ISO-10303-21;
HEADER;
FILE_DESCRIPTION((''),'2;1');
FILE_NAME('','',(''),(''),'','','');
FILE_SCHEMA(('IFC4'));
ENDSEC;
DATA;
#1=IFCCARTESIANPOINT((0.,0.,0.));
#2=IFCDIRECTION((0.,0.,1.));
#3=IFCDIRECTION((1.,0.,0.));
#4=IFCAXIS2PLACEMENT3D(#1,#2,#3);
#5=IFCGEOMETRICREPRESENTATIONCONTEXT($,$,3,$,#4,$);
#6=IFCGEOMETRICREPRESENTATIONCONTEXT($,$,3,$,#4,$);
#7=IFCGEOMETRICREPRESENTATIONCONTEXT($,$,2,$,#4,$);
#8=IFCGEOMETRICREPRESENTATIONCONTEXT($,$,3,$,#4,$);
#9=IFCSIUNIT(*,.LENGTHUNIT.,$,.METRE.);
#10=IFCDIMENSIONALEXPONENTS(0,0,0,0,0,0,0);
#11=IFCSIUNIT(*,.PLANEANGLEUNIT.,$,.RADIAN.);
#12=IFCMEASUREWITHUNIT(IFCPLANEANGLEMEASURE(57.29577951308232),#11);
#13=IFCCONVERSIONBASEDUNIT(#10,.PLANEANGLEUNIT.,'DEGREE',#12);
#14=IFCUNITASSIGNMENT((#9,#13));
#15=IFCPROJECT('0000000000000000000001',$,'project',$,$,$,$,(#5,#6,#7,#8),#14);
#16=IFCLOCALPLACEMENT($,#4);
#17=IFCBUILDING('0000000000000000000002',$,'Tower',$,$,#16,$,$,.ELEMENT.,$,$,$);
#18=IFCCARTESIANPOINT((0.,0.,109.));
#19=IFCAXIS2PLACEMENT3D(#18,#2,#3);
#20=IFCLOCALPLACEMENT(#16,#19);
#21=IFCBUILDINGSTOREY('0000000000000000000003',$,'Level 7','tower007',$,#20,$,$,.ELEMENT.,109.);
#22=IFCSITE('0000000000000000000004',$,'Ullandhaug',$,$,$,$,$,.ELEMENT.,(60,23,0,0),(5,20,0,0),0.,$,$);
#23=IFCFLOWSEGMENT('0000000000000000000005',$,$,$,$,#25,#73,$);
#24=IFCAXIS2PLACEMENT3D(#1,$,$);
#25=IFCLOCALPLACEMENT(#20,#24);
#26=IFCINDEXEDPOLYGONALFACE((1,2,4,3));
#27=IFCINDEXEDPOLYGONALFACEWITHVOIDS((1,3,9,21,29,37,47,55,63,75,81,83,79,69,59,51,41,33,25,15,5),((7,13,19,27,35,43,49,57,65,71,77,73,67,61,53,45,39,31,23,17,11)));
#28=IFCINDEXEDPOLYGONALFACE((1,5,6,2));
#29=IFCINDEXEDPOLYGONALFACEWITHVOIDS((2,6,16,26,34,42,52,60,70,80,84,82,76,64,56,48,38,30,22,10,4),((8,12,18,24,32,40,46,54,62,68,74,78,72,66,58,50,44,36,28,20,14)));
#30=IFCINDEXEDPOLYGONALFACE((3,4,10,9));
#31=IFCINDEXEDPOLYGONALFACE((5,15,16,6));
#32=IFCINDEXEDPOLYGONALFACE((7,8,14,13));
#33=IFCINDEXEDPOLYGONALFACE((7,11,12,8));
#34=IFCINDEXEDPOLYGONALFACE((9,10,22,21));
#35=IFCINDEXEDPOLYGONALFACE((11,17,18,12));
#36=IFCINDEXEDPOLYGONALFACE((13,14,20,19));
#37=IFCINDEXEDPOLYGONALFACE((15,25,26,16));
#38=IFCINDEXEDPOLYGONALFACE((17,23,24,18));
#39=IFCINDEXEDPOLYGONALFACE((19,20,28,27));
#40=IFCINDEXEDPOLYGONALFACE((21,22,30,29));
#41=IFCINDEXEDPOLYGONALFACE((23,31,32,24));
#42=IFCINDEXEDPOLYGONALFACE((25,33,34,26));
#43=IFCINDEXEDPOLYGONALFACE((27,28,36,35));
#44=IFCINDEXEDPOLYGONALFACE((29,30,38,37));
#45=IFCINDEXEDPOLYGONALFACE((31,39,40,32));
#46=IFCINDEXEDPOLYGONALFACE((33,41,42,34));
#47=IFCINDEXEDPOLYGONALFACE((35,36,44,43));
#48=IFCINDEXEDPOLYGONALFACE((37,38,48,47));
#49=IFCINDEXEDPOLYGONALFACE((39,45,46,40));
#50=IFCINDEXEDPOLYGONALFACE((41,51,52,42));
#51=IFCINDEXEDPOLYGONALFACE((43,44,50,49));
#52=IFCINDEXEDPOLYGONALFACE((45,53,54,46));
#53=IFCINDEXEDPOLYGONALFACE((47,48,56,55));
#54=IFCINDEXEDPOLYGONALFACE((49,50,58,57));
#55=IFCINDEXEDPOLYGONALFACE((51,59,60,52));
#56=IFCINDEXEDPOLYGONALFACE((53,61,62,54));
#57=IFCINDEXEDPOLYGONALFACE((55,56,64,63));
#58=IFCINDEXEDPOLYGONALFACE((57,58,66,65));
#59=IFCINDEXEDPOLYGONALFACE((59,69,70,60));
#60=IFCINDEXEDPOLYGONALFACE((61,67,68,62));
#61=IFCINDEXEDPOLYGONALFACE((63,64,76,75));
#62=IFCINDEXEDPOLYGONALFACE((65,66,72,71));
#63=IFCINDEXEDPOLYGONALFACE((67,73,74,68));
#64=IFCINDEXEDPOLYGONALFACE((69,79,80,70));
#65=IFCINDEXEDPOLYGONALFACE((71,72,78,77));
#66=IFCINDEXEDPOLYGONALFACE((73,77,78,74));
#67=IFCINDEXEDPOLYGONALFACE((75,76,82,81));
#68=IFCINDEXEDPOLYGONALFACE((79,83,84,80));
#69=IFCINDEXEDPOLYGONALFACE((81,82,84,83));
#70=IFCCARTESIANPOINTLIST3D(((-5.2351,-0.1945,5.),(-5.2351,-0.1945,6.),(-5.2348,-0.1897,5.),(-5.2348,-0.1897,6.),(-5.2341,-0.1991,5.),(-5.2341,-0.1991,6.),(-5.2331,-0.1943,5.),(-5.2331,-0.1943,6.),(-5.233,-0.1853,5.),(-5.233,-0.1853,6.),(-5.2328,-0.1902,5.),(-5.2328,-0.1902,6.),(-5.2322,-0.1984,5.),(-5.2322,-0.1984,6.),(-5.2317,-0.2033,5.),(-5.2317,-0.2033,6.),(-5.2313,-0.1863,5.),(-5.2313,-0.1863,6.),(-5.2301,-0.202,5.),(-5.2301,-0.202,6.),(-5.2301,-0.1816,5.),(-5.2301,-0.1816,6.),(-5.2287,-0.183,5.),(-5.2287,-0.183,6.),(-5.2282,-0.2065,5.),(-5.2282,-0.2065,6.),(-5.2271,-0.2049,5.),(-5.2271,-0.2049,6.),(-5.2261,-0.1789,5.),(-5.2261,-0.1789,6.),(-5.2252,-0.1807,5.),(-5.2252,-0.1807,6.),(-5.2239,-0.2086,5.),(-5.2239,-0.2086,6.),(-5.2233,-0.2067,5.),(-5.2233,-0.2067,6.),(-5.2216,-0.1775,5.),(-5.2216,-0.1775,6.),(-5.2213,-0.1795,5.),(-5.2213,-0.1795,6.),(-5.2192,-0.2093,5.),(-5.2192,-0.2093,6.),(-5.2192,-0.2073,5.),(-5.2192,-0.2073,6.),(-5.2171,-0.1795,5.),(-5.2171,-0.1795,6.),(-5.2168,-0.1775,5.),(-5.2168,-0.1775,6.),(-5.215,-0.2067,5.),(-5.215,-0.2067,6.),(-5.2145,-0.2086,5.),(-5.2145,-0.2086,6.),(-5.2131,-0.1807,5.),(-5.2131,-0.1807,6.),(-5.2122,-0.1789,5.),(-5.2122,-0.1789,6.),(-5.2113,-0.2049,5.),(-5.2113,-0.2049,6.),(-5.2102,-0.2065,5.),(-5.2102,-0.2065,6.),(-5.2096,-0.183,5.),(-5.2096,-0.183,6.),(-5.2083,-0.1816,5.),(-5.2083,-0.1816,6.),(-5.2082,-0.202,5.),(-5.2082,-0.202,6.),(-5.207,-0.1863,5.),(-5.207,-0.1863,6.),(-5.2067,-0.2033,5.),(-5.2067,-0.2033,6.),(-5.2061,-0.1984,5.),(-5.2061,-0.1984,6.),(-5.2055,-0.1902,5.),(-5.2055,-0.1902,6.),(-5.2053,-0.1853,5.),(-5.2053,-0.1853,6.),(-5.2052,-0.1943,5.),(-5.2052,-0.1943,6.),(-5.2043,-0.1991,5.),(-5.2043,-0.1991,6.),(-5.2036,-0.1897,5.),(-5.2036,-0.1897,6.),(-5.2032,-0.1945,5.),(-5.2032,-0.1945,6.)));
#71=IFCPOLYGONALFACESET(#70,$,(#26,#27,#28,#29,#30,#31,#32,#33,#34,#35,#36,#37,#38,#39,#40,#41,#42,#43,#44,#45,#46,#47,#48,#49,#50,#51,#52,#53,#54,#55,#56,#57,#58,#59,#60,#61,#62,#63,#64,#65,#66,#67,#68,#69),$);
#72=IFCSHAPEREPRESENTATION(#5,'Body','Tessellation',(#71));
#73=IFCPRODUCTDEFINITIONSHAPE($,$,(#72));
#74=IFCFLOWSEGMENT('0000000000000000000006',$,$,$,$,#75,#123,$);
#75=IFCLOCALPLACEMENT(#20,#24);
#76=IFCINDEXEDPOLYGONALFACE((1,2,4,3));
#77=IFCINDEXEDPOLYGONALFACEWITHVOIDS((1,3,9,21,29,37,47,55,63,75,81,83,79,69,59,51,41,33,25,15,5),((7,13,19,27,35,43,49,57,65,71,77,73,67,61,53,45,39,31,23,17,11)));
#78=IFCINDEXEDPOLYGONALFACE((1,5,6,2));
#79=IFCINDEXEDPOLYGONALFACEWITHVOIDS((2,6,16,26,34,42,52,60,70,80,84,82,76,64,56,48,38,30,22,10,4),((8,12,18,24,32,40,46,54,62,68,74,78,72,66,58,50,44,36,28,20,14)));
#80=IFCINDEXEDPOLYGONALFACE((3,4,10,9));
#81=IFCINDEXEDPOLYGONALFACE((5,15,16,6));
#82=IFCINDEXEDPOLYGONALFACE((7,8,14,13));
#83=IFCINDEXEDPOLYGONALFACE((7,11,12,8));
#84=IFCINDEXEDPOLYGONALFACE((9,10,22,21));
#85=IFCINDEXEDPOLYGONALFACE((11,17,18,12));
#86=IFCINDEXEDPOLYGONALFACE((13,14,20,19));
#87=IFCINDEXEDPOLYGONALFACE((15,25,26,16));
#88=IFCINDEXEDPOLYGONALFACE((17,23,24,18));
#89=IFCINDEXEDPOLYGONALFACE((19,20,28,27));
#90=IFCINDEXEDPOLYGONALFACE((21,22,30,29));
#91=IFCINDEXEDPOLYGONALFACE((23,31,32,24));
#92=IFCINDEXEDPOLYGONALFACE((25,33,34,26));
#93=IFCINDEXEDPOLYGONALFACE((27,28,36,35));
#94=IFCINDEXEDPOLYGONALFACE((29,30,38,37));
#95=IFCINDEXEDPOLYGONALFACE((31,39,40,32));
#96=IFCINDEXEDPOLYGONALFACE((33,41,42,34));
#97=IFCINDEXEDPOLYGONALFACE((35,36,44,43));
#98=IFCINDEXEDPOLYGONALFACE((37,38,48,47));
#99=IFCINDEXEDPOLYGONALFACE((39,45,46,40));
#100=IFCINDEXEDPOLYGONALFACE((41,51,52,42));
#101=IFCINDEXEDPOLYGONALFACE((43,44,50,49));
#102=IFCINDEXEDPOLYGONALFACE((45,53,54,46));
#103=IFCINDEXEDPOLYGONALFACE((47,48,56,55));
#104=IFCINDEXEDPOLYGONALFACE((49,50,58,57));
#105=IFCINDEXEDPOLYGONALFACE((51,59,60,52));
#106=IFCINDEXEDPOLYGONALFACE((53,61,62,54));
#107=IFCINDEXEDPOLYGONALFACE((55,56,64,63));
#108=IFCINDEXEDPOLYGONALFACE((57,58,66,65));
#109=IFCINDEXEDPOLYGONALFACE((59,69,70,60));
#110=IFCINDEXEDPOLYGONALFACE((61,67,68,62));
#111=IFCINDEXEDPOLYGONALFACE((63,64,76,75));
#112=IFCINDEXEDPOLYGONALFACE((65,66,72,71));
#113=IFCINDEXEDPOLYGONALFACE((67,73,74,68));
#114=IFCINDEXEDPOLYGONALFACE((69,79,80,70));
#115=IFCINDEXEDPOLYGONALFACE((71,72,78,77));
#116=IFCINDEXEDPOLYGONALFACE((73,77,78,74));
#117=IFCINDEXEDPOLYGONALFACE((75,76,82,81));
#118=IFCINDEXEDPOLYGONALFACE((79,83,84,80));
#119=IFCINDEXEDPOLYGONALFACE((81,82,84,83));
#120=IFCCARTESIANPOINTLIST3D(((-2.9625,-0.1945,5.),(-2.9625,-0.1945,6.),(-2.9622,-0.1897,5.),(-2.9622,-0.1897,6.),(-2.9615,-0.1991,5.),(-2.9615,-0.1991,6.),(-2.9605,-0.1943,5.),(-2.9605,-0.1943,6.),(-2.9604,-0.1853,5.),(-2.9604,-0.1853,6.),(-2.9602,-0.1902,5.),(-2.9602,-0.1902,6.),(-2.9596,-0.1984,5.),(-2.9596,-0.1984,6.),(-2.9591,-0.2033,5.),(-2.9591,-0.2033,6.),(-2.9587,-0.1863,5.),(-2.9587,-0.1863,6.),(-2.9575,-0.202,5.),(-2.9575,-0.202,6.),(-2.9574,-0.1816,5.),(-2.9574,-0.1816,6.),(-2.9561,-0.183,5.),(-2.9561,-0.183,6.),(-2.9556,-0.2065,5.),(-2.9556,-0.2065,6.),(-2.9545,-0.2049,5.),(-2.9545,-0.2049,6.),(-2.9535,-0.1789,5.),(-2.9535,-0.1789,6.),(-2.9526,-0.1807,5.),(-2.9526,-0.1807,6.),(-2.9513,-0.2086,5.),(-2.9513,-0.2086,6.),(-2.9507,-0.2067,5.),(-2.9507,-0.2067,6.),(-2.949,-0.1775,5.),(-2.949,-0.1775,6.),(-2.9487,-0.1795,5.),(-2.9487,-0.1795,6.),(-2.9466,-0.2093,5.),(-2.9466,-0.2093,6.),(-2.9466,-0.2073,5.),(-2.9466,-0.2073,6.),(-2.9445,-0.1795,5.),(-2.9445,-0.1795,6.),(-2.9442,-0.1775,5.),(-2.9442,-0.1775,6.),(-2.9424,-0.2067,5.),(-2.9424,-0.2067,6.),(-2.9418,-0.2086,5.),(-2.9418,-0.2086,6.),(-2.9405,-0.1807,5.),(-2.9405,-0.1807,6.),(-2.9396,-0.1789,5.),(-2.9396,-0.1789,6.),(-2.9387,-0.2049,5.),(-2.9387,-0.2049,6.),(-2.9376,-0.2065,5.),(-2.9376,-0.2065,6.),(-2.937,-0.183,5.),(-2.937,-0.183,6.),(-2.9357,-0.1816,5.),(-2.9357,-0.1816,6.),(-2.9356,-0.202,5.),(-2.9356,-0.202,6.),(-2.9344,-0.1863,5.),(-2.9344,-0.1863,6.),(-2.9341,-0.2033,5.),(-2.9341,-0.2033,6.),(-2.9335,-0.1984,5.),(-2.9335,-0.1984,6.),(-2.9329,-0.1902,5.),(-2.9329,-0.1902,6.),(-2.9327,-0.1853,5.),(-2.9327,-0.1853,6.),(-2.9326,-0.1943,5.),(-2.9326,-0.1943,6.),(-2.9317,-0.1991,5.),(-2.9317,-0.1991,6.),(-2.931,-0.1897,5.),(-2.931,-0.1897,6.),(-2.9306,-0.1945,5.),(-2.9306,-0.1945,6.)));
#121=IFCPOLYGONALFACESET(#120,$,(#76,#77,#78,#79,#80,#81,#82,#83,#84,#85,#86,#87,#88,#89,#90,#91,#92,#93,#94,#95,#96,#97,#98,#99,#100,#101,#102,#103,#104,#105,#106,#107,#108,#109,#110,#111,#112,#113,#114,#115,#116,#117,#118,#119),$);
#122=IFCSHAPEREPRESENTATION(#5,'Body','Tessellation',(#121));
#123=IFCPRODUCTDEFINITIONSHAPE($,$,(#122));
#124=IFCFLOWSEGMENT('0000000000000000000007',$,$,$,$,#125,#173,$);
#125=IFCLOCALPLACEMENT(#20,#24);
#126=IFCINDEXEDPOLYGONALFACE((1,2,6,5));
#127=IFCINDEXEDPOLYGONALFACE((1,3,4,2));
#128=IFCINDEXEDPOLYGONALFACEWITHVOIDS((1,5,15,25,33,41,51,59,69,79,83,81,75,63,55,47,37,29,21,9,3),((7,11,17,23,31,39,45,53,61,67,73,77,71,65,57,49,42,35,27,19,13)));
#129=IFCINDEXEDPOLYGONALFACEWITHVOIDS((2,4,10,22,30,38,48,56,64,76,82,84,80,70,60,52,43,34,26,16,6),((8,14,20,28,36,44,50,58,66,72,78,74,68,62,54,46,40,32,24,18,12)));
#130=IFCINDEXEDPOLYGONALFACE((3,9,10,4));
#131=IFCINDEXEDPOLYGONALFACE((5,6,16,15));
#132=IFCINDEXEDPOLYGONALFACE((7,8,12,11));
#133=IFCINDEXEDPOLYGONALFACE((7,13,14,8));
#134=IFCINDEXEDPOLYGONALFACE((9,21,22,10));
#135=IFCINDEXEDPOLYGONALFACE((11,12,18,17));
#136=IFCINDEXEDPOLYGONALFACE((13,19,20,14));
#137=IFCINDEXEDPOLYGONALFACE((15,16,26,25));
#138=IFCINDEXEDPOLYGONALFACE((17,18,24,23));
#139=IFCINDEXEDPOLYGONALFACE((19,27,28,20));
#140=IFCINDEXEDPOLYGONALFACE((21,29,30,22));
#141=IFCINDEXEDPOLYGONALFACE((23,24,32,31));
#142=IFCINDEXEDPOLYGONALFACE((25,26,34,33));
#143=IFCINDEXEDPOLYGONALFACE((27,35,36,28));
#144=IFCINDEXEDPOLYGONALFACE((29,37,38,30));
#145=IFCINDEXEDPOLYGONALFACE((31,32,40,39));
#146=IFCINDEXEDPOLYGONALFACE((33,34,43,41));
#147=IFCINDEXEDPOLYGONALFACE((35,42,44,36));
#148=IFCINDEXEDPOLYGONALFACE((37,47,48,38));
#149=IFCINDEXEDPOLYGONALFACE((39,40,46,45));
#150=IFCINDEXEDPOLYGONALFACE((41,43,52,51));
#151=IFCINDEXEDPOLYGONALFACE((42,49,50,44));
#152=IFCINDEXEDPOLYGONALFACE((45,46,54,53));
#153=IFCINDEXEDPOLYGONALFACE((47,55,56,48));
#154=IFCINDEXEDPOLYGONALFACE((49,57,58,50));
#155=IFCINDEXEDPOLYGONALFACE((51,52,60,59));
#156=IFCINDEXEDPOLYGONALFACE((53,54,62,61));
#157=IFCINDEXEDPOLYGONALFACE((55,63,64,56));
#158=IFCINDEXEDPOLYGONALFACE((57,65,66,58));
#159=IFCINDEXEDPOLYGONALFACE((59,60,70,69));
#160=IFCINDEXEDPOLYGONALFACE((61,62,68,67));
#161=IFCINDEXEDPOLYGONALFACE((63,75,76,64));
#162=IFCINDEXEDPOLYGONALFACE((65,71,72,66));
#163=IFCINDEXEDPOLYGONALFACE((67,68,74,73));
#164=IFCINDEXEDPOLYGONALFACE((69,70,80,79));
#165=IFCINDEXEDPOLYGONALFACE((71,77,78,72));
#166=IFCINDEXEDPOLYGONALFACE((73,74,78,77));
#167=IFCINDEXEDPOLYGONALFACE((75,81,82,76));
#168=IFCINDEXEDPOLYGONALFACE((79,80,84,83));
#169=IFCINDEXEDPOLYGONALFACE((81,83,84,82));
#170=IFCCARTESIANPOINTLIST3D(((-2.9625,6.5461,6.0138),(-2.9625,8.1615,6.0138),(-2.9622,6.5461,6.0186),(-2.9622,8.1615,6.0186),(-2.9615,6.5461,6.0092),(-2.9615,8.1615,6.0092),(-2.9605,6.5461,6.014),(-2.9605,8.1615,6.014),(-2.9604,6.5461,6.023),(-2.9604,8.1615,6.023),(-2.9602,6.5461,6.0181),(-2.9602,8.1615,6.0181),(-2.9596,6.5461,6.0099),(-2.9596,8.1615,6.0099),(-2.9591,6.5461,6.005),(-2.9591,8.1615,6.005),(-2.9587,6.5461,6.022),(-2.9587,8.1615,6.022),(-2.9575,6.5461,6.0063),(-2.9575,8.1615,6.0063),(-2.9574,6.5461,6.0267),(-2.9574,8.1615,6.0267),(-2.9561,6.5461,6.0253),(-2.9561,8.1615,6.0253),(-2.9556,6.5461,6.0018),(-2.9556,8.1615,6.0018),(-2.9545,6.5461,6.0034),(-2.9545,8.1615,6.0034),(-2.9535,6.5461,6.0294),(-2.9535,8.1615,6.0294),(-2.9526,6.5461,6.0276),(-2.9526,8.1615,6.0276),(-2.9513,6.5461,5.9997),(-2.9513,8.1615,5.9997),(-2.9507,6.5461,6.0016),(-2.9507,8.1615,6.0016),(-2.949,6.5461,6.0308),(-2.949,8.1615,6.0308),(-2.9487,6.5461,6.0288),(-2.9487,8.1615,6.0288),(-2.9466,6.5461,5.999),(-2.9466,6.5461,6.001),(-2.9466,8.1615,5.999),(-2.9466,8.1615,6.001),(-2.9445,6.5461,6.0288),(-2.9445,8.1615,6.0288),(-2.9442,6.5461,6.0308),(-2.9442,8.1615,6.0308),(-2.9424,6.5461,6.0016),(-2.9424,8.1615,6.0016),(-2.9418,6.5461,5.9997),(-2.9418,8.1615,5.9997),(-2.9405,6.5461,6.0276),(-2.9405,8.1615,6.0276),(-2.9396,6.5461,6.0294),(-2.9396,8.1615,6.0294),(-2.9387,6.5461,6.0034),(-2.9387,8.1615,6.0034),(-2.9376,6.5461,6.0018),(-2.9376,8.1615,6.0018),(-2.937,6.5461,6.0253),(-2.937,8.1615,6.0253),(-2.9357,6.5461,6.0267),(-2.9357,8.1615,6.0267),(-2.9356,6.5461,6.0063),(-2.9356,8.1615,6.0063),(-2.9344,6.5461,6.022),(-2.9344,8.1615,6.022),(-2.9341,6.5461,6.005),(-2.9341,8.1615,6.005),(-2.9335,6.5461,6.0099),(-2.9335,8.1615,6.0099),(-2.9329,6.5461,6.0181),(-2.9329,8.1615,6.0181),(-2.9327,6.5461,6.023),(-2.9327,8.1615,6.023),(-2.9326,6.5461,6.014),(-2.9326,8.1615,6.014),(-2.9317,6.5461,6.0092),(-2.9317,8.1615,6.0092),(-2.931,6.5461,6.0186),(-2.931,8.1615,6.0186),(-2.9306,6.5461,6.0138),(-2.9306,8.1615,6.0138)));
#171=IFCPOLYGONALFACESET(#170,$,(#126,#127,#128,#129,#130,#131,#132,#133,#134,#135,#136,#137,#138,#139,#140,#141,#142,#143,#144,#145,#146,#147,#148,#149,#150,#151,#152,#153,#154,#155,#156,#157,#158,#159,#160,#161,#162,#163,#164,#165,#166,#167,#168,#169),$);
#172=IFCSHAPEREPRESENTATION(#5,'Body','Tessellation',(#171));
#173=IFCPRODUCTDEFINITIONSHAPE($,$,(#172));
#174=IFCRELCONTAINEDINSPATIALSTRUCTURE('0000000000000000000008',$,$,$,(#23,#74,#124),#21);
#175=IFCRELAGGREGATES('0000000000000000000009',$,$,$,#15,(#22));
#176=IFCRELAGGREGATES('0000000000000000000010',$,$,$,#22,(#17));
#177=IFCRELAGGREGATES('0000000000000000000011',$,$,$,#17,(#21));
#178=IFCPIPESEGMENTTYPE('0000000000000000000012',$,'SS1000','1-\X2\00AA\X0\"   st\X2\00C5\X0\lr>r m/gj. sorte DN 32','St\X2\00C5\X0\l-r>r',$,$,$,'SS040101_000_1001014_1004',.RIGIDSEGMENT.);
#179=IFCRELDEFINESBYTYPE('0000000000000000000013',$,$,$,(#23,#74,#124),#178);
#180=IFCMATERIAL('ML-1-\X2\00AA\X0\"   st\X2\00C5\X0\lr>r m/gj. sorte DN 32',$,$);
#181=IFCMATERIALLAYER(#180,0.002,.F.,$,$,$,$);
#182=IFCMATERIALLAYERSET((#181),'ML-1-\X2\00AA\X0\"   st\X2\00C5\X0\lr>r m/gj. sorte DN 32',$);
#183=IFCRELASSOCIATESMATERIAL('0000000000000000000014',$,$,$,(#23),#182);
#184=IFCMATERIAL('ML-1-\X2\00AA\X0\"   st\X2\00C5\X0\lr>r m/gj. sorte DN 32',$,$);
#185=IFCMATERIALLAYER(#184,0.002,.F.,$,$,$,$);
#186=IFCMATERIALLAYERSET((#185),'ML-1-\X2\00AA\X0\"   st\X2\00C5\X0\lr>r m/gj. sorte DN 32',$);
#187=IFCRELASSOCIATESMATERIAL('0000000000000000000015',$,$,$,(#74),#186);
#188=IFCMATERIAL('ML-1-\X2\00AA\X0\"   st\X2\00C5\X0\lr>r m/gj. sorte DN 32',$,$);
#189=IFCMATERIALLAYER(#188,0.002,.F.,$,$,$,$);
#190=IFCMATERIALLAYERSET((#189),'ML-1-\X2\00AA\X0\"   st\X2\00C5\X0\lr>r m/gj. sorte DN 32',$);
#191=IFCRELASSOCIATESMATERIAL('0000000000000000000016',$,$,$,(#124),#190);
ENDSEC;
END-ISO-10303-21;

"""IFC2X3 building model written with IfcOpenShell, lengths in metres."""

from ifc_helpers import new_model, entity, si_unit, converted_unit, frame, origin_with_axes, origin_2d_with_axis, place, context, project, spatial, hollow_circle, extrude, material, layer, layer_set, layer_usage, type_object, element, save


model = new_model("IFC2X3")

# Units and contexts
context_of_model_1 = context(None, 3, world=origin_with_axes())
context_of_model_2 = context(None, 3, world=origin_with_axes())
context_of_model_3 = context(None, 2, world=origin_with_axes())
context_of_model_4 = context(None, 3, world=origin_with_axes())
ifc_project = project(units=[si_unit("LENGTHUNIT", "METRE"), converted_unit("PLANEANGLEUNIT", "DEGREE", entity("IfcPlaneAngleMeasure", 57.29577951308232), si_unit("PLANEANGLEUNIT", "RADIAN"), dimensions=[0, 0, 0, 0, 0, 0, 0])], contexts=[context_of_model_1, context_of_model_2, context_of_model_3, context_of_model_4])

# Site, building, storey
site = spatial("IfcSite", under=ifc_project, Name="Ullandhaug", CompositionType="ELEMENT", RefLatitude=(60, 23, 0, 0), RefLongitude=(5, 20, 0, 0), RefElevation=0.0)
building_placement = place(None, origin_with_axes())
building = spatial("IfcBuilding", under=site, at=building_placement, Name="Tower", CompositionType="ELEMENT")
storey_placement = place(building_placement, frame((0.0, 0.0, 109.0), z_axis=(0.0, 0.0, 1.0), x_axis=(1.0, 0.0, 0.0)))
storey = spatial("IfcBuildingStorey", under=building, at=storey_placement, Name="Level 7", Description="tower007", CompositionType="ELEMENT", Elevation=109.0)

# Flow segments
pipe_segment_type_1 = type_object("IfcPipeSegmentType", Name="SS1000", Description="1-ª\"   stÅlr>r m/gj. sorte DN 32", ApplicableOccurrence="StÅl-r>r", ElementType="SS040101_000_1001014_1004", PredefinedType="RIGIDSEGMENT")
ifc_material_1 = material(Name="ML-1-ª\"   stÅlr>r m/gj. sorte DN 32")
ifc_layer_1 = layer(ifc_material_1, 0.002, ventilated=False)
ifc_layer_set_1 = layer_set([ifc_layer_1], Name="ML-1-ª\"   stÅlr>r m/gj. sorte DN 32")
ifc_layer_usage_1 = layer_usage(ifc_layer_set_1, "AXIS2", "POSITIVE", 0.0)
flow_segment_1_placement = place(storey_placement, frame((-5.2192, -0.1933, 5.0), z_axis=(0.0, 0.0, 1.0), x_axis=(0.0, -1.0, 0.0)))
element("IfcFlowSegment", 1, at=flow_segment_1_placement, inside=storey, type_object=pipe_segment_type_1, material=ifc_layer_usage_1, context=context_of_model_1, shape_type="SweptSolid", body=[
    extrude(hollow_circle(Radius=0.016, WallThickness=0.002, at=origin_2d_with_axis()), origin_with_axes(), (0.0, 0.0, 1.0), 1.0),
])
ifc_material_2 = material(Name="ML-1-ª\"   stÅlr>r m/gj. sorte DN 32")
ifc_layer_2 = layer(ifc_material_2, 0.002, ventilated=False)
ifc_layer_set_2 = layer_set([ifc_layer_2], Name="ML-1-ª\"   stÅlr>r m/gj. sorte DN 32")
ifc_layer_usage_2 = layer_usage(ifc_layer_set_2, "AXIS2", "POSITIVE", 0.0)
flow_segment_2_placement = place(storey_placement, frame((-2.9466, -0.1933, 5.0), z_axis=(0.0, 0.0, 1.0), x_axis=(0.0, -1.0, 0.0)))
element("IfcFlowSegment", 2, at=flow_segment_2_placement, inside=storey, type_object=pipe_segment_type_1, material=ifc_layer_usage_2, context=context_of_model_1, shape_type="SweptSolid", body=[
    extrude(hollow_circle(Radius=0.016, WallThickness=0.002, at=origin_2d_with_axis()), origin_with_axes(), (0.0, 0.0, 1.0), 1.0),
])
ifc_material_3 = material(Name="ML-1-ª\"   stÅlr>r m/gj. sorte DN 32")
ifc_layer_3 = layer(ifc_material_3, 0.002, ventilated=False)
ifc_layer_set_3 = layer_set([ifc_layer_3], Name="ML-1-ª\"   stÅlr>r m/gj. sorte DN 32")
ifc_layer_usage_3 = layer_usage(ifc_layer_set_3, "AXIS2", "POSITIVE", 0.0)
flow_segment_3_placement = place(storey_placement, frame((-2.9466, 6.5461, 6.015), z_axis=(0.0, 1.0, 0.0), x_axis=(0.0, 0.0, -1.0)))
element("IfcFlowSegment", 3, at=flow_segment_3_placement, inside=storey, type_object=pipe_segment_type_1, material=ifc_layer_usage_3, context=context_of_model_1, shape_type="SweptSolid", body=[
    extrude(hollow_circle(Radius=0.016, WallThickness=0.002, at=origin_2d_with_axis()), origin_with_axes(), (0.0, 0.0, 1.0), 1.6154),
])

save(model, "model.ifc")
